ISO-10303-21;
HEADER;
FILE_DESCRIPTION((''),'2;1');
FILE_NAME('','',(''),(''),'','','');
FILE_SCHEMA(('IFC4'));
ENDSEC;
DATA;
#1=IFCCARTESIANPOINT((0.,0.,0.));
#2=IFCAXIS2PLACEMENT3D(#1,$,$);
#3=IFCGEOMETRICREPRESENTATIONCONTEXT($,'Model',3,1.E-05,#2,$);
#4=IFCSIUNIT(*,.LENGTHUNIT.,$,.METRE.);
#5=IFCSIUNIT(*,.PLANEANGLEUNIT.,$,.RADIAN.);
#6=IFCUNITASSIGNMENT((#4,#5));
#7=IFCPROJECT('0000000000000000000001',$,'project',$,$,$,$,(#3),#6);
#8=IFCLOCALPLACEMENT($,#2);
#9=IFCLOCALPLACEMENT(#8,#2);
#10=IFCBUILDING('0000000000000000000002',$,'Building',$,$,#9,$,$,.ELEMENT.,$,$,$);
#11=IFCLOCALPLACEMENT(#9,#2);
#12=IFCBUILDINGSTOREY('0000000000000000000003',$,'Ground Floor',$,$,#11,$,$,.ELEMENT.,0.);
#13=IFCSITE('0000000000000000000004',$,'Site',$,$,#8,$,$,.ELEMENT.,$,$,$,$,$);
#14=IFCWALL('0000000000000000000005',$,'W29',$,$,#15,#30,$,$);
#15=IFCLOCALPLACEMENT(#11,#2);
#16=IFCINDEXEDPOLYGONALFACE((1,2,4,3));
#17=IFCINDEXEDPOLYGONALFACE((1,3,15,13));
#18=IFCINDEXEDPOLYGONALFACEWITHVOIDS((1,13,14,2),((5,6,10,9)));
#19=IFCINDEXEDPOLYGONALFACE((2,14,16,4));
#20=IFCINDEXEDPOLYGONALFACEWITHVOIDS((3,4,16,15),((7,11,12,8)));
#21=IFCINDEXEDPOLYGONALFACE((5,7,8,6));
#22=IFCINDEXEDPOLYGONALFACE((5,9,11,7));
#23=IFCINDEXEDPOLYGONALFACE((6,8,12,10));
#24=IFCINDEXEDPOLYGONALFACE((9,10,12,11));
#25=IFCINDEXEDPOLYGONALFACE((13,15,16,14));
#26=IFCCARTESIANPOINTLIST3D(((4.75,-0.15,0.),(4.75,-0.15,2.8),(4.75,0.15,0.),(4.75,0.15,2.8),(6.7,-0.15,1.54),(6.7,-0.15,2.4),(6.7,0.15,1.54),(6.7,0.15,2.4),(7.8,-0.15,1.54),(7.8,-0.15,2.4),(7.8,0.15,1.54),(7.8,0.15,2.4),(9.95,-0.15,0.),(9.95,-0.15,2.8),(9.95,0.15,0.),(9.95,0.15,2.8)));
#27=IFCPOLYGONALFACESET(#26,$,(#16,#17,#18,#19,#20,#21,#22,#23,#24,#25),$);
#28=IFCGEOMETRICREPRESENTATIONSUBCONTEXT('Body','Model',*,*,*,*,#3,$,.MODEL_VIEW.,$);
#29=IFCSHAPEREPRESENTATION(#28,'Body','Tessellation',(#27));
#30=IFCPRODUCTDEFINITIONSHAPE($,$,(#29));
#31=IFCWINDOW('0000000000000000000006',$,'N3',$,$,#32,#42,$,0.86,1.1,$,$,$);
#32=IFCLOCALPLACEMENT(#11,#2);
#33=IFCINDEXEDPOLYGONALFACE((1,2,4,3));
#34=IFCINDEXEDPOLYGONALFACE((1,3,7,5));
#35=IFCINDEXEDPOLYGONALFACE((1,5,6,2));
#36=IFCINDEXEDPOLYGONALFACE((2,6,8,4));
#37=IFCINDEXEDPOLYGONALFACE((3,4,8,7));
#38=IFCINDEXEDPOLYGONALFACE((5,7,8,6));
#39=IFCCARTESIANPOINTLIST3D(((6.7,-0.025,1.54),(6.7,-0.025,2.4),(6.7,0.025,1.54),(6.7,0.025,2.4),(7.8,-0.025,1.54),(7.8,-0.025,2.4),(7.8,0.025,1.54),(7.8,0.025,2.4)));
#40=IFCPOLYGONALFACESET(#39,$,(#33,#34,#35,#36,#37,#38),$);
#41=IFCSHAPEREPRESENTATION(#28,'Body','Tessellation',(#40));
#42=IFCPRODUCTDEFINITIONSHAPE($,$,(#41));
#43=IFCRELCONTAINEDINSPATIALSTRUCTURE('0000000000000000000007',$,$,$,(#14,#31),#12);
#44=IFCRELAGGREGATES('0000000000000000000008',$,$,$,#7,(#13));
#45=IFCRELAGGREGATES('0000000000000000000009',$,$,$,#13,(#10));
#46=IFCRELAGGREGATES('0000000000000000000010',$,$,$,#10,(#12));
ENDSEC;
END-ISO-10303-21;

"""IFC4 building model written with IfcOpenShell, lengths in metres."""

from ifc_helpers import new_model, si_unit, frame, frame_2d, origin, origin_2d, place, context, subcontext, project, spatial, rectangle, extrude, element, fill, save


model = new_model("IFC4")

# Units and contexts
model_context = context("Model", 3, precision=1e-05, world=origin())
body_context = subcontext(model_context, "Body", "Model", "MODEL_VIEW")
ifc_project = project(units=[si_unit("LENGTHUNIT", "METRE"), si_unit("PLANEANGLEUNIT", "RADIAN")], contexts=[model_context])

# Site, building, storey
site_placement = place(None, origin())
site = spatial("IfcSite", under=ifc_project, at=site_placement, Name="Site", CompositionType="ELEMENT")
building_placement = place(site_placement, origin())
building = spatial("IfcBuilding", under=site, at=building_placement, Name="Building", CompositionType="ELEMENT")
storey_placement = place(building_placement, origin())
storey = spatial("IfcBuildingStorey", under=building, at=storey_placement, Name="Ground Floor", CompositionType="ELEMENT", Elevation=0.0)

# Wall, opening, window
wall_1_placement = place(storey_placement, frame((4.9, 0.0, 0.0), x_axis=(1.0, 0.0, 0.0)))
wall_1 = element("IfcWall", 1, at=wall_1_placement, inside=storey, Name="W29", context=body_context, shape_type="SweptSolid", body=[
    extrude(rectangle(XDim=5.2, YDim=0.3, at=frame_2d((2.45, 0.0))), origin(), (0.0, 0.0, 1.0), 2.8),
])
opening_1_placement = place(wall_1_placement, frame((2.35, 0.0, 1.54)))
opening_1 = element("IfcOpeningElement", 2, at=opening_1_placement, cuts=wall_1, context=body_context, shape_type="SweptSolid", body=[
    extrude(rectangle(XDim=1.1, YDim=0.4, at=origin_2d()), origin(), (0.0, 0.0, 1.0), 0.86),
])
window_1_placement = place(opening_1_placement, origin())
window_1 = element("IfcWindow", 3, at=window_1_placement, inside=storey, Name="N3", OverallHeight=0.86, OverallWidth=1.1, context=body_context, shape_type="SweptSolid", body=[
    extrude(rectangle(XDim=1.1, YDim=0.05, at=origin_2d()), origin(), (0.0, 0.0, 1.0), 0.86),
])
fill(opening_1, window_1)

save(model, "model.ifc")
